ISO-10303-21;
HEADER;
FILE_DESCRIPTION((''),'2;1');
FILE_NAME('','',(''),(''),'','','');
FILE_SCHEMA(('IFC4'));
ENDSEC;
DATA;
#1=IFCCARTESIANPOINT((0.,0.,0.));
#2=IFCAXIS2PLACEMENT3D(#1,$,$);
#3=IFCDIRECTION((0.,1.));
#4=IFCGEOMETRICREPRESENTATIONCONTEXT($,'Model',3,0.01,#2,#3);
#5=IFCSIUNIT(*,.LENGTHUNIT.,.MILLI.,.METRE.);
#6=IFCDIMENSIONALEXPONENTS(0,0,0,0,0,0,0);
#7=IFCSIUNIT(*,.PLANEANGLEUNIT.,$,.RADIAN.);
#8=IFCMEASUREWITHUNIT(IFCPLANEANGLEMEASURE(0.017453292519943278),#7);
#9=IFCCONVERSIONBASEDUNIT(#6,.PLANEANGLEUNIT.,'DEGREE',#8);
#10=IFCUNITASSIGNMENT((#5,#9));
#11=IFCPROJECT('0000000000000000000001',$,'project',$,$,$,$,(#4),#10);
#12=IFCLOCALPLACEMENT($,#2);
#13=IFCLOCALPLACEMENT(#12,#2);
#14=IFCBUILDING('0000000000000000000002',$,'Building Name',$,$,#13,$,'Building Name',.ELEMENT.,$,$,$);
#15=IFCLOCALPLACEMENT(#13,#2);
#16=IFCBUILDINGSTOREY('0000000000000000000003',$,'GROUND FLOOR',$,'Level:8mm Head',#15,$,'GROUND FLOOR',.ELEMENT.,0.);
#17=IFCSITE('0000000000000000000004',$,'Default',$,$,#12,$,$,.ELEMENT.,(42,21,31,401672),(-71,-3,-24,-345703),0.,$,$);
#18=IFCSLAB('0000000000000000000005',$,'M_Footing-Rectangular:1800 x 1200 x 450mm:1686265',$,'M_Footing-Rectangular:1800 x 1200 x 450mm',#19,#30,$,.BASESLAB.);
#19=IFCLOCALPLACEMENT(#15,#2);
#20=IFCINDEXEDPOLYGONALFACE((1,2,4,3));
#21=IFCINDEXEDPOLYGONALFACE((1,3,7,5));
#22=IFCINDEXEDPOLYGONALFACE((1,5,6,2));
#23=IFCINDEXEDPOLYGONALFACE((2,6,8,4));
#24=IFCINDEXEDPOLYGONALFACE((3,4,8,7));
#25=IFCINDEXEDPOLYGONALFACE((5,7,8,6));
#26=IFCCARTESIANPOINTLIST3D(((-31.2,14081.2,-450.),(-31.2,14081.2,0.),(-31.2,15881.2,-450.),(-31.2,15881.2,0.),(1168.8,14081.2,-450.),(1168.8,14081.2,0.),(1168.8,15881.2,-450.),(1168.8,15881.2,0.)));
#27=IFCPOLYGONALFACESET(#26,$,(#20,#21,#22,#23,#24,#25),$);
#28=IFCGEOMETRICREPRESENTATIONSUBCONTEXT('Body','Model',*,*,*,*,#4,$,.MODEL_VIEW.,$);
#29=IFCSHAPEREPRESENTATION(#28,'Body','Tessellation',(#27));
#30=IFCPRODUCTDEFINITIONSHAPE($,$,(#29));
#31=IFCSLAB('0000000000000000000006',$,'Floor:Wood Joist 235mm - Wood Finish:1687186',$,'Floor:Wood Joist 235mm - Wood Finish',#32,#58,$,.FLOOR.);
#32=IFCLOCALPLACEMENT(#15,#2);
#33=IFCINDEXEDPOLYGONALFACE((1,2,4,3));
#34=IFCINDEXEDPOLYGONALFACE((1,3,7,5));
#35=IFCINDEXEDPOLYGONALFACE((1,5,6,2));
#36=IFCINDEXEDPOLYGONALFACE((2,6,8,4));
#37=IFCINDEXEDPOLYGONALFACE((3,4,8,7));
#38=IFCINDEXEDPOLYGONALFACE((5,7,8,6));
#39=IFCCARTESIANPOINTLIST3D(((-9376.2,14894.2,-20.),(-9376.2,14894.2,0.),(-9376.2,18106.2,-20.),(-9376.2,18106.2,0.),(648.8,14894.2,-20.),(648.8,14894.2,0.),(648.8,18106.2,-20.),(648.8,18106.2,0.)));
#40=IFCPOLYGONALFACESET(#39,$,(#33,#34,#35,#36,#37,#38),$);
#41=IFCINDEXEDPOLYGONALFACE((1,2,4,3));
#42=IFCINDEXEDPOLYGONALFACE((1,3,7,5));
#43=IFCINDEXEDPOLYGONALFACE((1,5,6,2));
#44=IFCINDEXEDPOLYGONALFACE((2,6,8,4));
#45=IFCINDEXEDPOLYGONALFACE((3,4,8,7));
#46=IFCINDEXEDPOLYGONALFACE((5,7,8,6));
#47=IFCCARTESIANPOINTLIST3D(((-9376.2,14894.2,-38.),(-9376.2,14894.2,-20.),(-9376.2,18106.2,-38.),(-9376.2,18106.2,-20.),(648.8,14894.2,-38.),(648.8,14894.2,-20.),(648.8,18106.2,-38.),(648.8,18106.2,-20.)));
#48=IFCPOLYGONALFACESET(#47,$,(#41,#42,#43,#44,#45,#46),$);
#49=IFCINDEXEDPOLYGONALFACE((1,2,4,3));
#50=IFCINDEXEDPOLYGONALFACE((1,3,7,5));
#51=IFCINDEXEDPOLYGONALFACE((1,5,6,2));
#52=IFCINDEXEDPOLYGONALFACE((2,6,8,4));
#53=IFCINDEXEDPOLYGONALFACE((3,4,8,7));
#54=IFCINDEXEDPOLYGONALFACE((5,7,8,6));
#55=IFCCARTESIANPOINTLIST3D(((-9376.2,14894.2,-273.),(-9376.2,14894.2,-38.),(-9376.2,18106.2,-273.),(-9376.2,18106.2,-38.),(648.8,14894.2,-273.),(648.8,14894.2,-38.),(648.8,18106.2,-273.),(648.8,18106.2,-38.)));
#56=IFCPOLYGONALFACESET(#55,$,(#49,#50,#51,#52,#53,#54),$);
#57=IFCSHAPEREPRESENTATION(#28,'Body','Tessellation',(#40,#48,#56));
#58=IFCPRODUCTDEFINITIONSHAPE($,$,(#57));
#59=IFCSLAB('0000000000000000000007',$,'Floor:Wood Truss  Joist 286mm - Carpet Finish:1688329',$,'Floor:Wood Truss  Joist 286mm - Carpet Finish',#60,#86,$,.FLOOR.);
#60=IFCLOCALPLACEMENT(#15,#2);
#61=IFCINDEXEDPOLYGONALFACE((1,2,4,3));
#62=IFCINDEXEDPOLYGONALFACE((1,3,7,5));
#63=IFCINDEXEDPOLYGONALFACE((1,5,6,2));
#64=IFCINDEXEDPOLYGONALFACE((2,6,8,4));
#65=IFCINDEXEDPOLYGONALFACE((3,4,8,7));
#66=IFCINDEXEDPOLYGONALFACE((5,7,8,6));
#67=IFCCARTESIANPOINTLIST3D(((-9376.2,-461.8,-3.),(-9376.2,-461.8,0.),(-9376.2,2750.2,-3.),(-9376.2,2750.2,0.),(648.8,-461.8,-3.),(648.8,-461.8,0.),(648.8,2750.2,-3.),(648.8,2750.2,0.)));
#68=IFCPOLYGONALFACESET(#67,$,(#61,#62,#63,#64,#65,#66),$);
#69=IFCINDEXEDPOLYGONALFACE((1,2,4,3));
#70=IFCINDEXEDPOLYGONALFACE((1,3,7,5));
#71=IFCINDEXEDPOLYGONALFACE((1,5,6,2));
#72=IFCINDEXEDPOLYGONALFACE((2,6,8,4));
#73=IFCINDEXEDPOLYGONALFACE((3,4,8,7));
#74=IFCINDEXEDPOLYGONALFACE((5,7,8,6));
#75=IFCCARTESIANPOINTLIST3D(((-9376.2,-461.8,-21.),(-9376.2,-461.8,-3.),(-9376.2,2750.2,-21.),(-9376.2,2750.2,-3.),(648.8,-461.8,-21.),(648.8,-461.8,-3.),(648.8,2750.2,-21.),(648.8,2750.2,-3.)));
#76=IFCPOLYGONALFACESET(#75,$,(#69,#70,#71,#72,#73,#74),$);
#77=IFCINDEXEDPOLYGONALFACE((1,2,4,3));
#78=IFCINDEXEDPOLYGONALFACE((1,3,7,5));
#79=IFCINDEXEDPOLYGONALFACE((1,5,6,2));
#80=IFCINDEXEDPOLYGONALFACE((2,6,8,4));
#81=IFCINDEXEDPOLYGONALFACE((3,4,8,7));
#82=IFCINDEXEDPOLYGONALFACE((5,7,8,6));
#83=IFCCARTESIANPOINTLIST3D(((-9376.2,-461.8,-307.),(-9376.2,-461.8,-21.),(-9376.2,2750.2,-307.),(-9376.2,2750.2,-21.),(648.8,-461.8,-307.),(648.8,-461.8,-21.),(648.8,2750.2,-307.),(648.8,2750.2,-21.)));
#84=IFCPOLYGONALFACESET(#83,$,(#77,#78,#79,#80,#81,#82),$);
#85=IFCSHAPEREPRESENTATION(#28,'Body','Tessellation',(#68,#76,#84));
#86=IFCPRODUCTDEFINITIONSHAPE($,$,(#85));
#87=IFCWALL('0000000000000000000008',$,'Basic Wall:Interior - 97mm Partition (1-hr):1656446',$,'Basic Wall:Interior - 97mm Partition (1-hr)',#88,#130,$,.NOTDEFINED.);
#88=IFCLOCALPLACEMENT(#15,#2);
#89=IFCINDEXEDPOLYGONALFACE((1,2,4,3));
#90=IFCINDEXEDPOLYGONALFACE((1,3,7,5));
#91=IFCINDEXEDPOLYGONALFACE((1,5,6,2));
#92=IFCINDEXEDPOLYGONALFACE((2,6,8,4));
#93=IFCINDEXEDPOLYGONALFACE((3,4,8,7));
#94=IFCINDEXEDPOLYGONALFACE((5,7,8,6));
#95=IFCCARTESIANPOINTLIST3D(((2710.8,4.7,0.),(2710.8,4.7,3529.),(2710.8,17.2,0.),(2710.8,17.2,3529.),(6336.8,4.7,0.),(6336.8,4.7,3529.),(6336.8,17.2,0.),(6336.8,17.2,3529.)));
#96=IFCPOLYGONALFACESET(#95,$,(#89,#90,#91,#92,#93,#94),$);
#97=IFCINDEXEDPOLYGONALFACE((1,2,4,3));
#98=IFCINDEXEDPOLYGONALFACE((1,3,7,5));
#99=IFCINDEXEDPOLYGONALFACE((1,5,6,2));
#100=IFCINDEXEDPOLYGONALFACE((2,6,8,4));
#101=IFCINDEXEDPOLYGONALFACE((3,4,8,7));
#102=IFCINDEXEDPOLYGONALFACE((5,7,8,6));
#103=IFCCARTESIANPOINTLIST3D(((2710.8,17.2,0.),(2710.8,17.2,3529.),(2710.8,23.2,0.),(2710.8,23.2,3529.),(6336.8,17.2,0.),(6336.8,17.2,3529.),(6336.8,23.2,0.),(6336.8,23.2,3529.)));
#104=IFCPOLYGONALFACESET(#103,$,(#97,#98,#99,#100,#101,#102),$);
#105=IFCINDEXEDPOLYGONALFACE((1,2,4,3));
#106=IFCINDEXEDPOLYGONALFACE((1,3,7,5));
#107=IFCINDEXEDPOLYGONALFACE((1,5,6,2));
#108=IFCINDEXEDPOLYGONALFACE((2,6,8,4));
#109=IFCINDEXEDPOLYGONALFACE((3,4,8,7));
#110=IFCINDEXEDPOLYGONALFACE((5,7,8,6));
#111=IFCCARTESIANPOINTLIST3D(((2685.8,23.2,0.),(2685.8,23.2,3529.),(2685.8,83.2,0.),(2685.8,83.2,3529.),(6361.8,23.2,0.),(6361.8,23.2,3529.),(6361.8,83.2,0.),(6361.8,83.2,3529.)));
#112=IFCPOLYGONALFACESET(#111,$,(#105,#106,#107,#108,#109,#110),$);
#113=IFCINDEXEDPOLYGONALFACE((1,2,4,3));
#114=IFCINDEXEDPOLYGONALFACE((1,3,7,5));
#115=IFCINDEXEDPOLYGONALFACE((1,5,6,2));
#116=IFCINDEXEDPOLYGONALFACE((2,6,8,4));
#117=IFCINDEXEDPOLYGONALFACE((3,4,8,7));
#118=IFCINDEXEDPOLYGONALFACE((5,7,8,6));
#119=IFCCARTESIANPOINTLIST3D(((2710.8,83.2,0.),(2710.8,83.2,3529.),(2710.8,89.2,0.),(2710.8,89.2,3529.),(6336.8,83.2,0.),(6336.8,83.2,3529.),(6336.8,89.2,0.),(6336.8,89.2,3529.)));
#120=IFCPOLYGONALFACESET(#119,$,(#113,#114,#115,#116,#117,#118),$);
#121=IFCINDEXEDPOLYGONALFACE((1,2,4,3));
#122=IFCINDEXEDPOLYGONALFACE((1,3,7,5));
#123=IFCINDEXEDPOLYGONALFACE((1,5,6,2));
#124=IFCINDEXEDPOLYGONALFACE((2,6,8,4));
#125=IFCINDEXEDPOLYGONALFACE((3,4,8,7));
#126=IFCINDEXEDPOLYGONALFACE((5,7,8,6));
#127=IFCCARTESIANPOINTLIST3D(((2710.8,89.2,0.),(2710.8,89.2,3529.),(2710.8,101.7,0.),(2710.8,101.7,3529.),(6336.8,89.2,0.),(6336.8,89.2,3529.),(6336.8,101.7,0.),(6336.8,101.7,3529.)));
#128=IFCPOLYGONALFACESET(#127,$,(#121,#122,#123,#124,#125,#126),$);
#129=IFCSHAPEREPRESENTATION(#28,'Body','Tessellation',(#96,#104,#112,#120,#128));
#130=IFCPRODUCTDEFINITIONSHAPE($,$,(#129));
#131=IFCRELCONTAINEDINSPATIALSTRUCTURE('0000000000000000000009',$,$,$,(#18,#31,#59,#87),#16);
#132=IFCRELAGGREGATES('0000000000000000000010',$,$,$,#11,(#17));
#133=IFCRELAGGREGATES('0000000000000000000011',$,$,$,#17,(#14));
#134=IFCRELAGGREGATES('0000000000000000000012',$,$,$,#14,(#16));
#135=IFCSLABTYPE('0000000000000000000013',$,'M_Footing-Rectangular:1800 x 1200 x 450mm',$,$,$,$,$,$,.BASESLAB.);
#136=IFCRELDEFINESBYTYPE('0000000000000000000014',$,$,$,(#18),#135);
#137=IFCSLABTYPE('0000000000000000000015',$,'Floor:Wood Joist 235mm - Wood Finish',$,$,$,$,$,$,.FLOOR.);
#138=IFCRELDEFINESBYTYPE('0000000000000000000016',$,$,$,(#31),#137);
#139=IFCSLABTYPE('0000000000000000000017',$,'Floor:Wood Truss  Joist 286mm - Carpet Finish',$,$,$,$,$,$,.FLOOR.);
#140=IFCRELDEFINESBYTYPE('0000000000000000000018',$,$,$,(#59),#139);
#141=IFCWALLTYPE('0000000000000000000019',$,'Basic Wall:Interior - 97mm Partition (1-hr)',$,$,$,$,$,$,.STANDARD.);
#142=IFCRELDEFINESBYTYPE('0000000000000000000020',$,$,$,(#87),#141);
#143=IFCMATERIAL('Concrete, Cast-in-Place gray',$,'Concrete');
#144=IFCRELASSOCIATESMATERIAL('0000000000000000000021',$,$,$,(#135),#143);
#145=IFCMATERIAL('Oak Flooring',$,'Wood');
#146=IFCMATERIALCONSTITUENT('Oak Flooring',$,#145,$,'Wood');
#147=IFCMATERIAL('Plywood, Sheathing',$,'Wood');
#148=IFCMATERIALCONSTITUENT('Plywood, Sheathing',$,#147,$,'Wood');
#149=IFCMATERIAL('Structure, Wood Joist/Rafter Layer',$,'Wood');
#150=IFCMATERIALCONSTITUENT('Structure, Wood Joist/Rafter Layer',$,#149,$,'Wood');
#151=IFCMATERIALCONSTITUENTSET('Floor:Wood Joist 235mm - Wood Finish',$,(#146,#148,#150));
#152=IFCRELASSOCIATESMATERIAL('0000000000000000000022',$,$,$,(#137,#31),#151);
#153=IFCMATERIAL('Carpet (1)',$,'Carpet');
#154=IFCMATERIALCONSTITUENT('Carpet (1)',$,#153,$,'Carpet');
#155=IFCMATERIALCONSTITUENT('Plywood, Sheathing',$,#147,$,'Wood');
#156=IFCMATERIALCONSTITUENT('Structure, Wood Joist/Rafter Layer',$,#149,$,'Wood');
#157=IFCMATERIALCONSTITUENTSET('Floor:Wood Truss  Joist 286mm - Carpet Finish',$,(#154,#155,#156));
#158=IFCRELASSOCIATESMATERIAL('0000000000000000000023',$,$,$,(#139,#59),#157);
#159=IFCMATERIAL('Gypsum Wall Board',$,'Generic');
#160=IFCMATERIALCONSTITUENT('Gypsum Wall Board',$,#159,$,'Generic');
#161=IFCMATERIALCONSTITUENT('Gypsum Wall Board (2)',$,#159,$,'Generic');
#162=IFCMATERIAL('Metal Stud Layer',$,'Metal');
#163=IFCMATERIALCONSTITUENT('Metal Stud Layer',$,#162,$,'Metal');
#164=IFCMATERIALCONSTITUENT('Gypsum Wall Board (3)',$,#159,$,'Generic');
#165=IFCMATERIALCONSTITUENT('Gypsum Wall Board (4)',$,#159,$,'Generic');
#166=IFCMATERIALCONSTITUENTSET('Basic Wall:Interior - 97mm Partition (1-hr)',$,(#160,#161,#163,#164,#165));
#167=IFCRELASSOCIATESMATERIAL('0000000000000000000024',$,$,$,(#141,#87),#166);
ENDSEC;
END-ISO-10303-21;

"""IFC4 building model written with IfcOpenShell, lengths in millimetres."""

from ifc_helpers import new_model, entity, si_unit, converted_unit, direction, frame, origin, place, context, subcontext, project, spatial, indexed_curve, outline, extrude, material, constituent, constituent_set, type_object, element, save


model = new_model("IFC4")

# Units and contexts
model_context = context("Model", 3, precision=0.01, world=origin(), true_north=direction((0.0, 1.0)))
body_context = subcontext(model_context, "Body", "Model", "MODEL_VIEW")
ifc_project = project(units=[si_unit("LENGTHUNIT", "METRE", prefix="MILLI"), converted_unit("PLANEANGLEUNIT", "DEGREE", entity("IfcPlaneAngleMeasure", 0.017453292519943278), si_unit("PLANEANGLEUNIT", "RADIAN"), dimensions=[0, 0, 0, 0, 0, 0, 0])], contexts=[model_context])

# Site, building, storey
site_placement = place(None, origin())
site = spatial("IfcSite", under=ifc_project, at=site_placement, Name="Default", CompositionType="ELEMENT", RefLatitude=(42, 21, 31, 401672), RefLongitude=(-71, -3, -24, -345703), RefElevation=0.0)
building_placement = place(site_placement, origin())
building = spatial("IfcBuilding", under=site, at=building_placement, Name="Building Name", LongName="Building Name", CompositionType="ELEMENT")
storey_placement = place(building_placement, origin())
storey = spatial("IfcBuildingStorey", under=building, at=storey_placement, Name="GROUND FLOOR", ObjectType="Level:8mm Head", LongName="GROUND FLOOR", CompositionType="ELEMENT", Elevation=0.0)

# Shared definitions
ifc_material_1 = material(Name="Concrete, Cast-in-Place gray", Category="Concrete")

# Slabs
slab_type_1 = type_object("IfcSlabType", Name="M_Footing-Rectangular:1800 x 1200 x 450mm", PredefinedType="BASESLAB", material=ifc_material_1)
slab_1_placement = place(storey_placement, origin())
element("IfcSlab", 1, at=slab_1_placement, inside=storey, type_object=slab_type_1, Name="M_Footing-Rectangular:1800 x 1200 x 450mm:1686265", ObjectType="M_Footing-Rectangular:1800 x 1200 x 450mm", PredefinedType="BASESLAB", context=body_context, shape_type="SweptSolid", body=[
    extrude(outline(indexed_curve([(-600.0, -900.0), (600.0, -900.0), (600.0, 900.0), (-600.0, 900.0), (-600.0, -900.0)], self_intersect=False)), frame((568.8, 14981.2, -450.0), z_axis=(0.0, 0.0, 1.0), x_axis=(-1.0, 0.0, 0.0)), (0.0, 0.0, 1.0), 450.0),
])
ifc_material_2 = material(Name="Oak Flooring", Category="Wood")
ifc_constituent_1 = constituent(ifc_material_2, Name="Oak Flooring", Category="Wood")
ifc_material_3 = material(Name="Plywood, Sheathing", Category="Wood")
ifc_constituent_2 = constituent(ifc_material_3, Name="Plywood, Sheathing", Category="Wood")
ifc_material_4 = material(Name="Structure, Wood Joist/Rafter Layer", Category="Wood")
ifc_constituent_3 = constituent(ifc_material_4, Name="Structure, Wood Joist/Rafter Layer", Category="Wood")
ifc_constituent_set_1 = constituent_set(constituents=[ifc_constituent_1, ifc_constituent_2, ifc_constituent_3], Name="Floor:Wood Joist 235mm - Wood Finish")
slab_type_2 = type_object("IfcSlabType", Name="Floor:Wood Joist 235mm - Wood Finish", PredefinedType="FLOOR", material=ifc_constituent_set_1)
slab_2_placement = place(storey_placement, origin())
element("IfcSlab", 2, at=slab_2_placement, inside=storey, type_object=slab_type_2, material=ifc_constituent_set_1, Name="Floor:Wood Joist 235mm - Wood Finish:1687186", ObjectType="Floor:Wood Joist 235mm - Wood Finish", PredefinedType="FLOOR", context=body_context, shape_type="SweptSolid", body=[
    extrude(outline(indexed_curve([(-5012.5, -1606.0), (5012.5, -1606.0), (5012.5, 1606.0), (-5012.5, 1606.0), (-5012.5, -1606.0)], self_intersect=False)), frame((-4363.7, 16500.2, -20.0), z_axis=(0.0, 0.0, 1.0), x_axis=(-1.0, 0.0, 0.0)), (0.0, 0.0, 1.0), 20.0),
    extrude(outline(indexed_curve([(-5012.5, -1606.0), (5012.5, -1606.0), (5012.5, 1606.0), (-5012.5, 1606.0), (-5012.5, -1606.0)], self_intersect=False)), frame((-4363.7, 16500.2, -38.0), z_axis=(0.0, 0.0, 1.0), x_axis=(-1.0, 0.0, 0.0)), (0.0, 0.0, 1.0), 18.0),
    extrude(outline(indexed_curve([(-5012.5, -1606.0), (5012.5, -1606.0), (5012.5, 1606.0), (-5012.5, 1606.0), (-5012.5, -1606.0)], self_intersect=False)), frame((-4363.7, 16500.2, -273.0), z_axis=(0.0, 0.0, 1.0), x_axis=(-1.0, 0.0, 0.0)), (0.0, 0.0, 1.0), 235.0),
])
ifc_material_5 = material(Name="Carpet (1)", Category="Carpet")
ifc_constituent_4 = constituent(ifc_material_5, Name="Carpet (1)", Category="Carpet")
ifc_constituent_5 = constituent(ifc_material_3, Name="Plywood, Sheathing", Category="Wood")
ifc_constituent_6 = constituent(ifc_material_4, Name="Structure, Wood Joist/Rafter Layer", Category="Wood")
ifc_constituent_set_2 = constituent_set(constituents=[ifc_constituent_4, ifc_constituent_5, ifc_constituent_6], Name="Floor:Wood Truss  Joist 286mm - Carpet Finish")
slab_type_3 = type_object("IfcSlabType", Name="Floor:Wood Truss  Joist 286mm - Carpet Finish", PredefinedType="FLOOR", material=ifc_constituent_set_2)
slab_3_placement = place(storey_placement, origin())
element("IfcSlab", 3, at=slab_3_placement, inside=storey, type_object=slab_type_3, material=ifc_constituent_set_2, Name="Floor:Wood Truss  Joist 286mm - Carpet Finish:1688329", ObjectType="Floor:Wood Truss  Joist 286mm - Carpet Finish", PredefinedType="FLOOR", context=body_context, shape_type="SweptSolid", body=[
    extrude(outline(indexed_curve([(-5012.5, -1606.0), (5012.5, -1606.0), (5012.5, 1606.0), (-5012.5, 1606.0), (-5012.5, -1606.0)], self_intersect=False)), frame((-4363.7, 1144.2, -3.0), z_axis=(0.0, 0.0, 1.0), x_axis=(-1.0, 0.0, 0.0)), (0.0, 0.0, 1.0), 3.0),
    extrude(outline(indexed_curve([(-5012.5, -1606.0), (5012.5, -1606.0), (5012.5, 1606.0), (-5012.5, 1606.0), (-5012.5, -1606.0)], self_intersect=False)), frame((-4363.7, 1144.2, -21.0), z_axis=(0.0, 0.0, 1.0), x_axis=(-1.0, 0.0, 0.0)), (0.0, 0.0, 1.0), 18.0),
    extrude(outline(indexed_curve([(-5012.5, -1606.0), (5012.5, -1606.0), (5012.5, 1606.0), (-5012.5, 1606.0), (-5012.5, -1606.0)], self_intersect=False)), frame((-4363.7, 1144.2, -307.0), z_axis=(0.0, 0.0, 1.0), x_axis=(-1.0, 0.0, 0.0)), (0.0, 0.0, 1.0), 286.0),
])

# Shared definitions
ifc_material_6 = material(Name="Gypsum Wall Board", Category="Generic")

# Wall
ifc_constituent_7 = constituent(ifc_material_6, Name="Gypsum Wall Board", Category="Generic")
ifc_constituent_8 = constituent(ifc_material_6, Name="Gypsum Wall Board (2)", Category="Generic")
ifc_material_7 = material(Name="Metal Stud Layer", Category="Metal")
ifc_constituent_9 = constituent(ifc_material_7, Name="Metal Stud Layer", Category="Metal")
ifc_constituent_10 = constituent(ifc_material_6, Name="Gypsum Wall Board (3)", Category="Generic")
ifc_constituent_11 = constituent(ifc_material_6, Name="Gypsum Wall Board (4)", Category="Generic")
ifc_constituent_set_3 = constituent_set(constituents=[ifc_constituent_7, ifc_constituent_8, ifc_constituent_9, ifc_constituent_10, ifc_constituent_11], Name="Basic Wall:Interior - 97mm Partition (1-hr)")
wall_type = type_object("IfcWallType", Name="Basic Wall:Interior - 97mm Partition (1-hr)", PredefinedType="STANDARD", material=ifc_constituent_set_3)
wall_placement = place(storey_placement, frame((6336.8, 53.2, 0.0), z_axis=(0.0, 0.0, 1.0), x_axis=(-1.0, 0.0, 0.0)))
element("IfcWall", 4, at=wall_placement, inside=storey, type_object=wall_type, material=ifc_constituent_set_3, Name="Basic Wall:Interior - 97mm Partition (1-hr):1656446", ObjectType="Basic Wall:Interior - 97mm Partition (1-hr)", PredefinedType="NOTDEFINED", context=body_context, shape_type="SweptSolid", body=[
    extrude(outline(indexed_curve([(-6.3, -1764.5), (6.2, -1764.5), (6.3, 1764.5), (-6.3, 1764.5), (-6.3, -1764.5)], self_intersect=False)), frame((3626.0, 42.2, 1764.5), z_axis=(-1.0, 0.0, 0.0), x_axis=(0.0, -1.0, 0.0)), (0.0, 0.0, 1.0), 3626.0),
    extrude(outline(indexed_curve([(-1764.5, -3.0), (1764.5, -3.0), (1764.5, 3.0), (-1764.5, 3.0), (-1764.5, -3.0)], self_intersect=False)), frame((3626.0, 33.0, 1764.5), z_axis=(-1.0, 0.0, 0.0), x_axis=(0.0, 0.0, 1.0)), (0.0, 0.0, 1.0), 3626.0),
    extrude(outline(indexed_curve([(-1764.5, -30.0), (1764.5, -30.0), (1764.5, 30.0), (-1764.5, 30.0), (-1764.5, -30.0)], self_intersect=False)), frame((3651.0, 0.0, 1764.5), z_axis=(-1.0, 0.0, 0.0), x_axis=(0.0, 0.0, 1.0)), (0.0, 0.0, 1.0), 3676.0),
    extrude(outline(indexed_curve([(-1764.5, -3.0), (1764.5, -3.0), (1764.5, 3.0), (-1764.5, 3.0), (-1764.5, -3.0)], self_intersect=False)), frame((3626.0, -33.0, 1764.5), z_axis=(-1.0, 0.0, 0.0), x_axis=(0.0, 0.0, 1.0)), (0.0, 0.0, 1.0), 3626.0),
    extrude(outline(indexed_curve([(-6.3, -1764.5), (6.2, -1764.5), (6.2, 1764.5), (-6.3, 1764.5), (-6.3, -1764.5)], self_intersect=False)), frame((3626.0, -42.2, 1764.5), z_axis=(-1.0, 0.0, 0.0), x_axis=(0.0, 1.0, 0.0)), (0.0, 0.0, 1.0), 3626.0),
])

save(model, "model.ifc")
